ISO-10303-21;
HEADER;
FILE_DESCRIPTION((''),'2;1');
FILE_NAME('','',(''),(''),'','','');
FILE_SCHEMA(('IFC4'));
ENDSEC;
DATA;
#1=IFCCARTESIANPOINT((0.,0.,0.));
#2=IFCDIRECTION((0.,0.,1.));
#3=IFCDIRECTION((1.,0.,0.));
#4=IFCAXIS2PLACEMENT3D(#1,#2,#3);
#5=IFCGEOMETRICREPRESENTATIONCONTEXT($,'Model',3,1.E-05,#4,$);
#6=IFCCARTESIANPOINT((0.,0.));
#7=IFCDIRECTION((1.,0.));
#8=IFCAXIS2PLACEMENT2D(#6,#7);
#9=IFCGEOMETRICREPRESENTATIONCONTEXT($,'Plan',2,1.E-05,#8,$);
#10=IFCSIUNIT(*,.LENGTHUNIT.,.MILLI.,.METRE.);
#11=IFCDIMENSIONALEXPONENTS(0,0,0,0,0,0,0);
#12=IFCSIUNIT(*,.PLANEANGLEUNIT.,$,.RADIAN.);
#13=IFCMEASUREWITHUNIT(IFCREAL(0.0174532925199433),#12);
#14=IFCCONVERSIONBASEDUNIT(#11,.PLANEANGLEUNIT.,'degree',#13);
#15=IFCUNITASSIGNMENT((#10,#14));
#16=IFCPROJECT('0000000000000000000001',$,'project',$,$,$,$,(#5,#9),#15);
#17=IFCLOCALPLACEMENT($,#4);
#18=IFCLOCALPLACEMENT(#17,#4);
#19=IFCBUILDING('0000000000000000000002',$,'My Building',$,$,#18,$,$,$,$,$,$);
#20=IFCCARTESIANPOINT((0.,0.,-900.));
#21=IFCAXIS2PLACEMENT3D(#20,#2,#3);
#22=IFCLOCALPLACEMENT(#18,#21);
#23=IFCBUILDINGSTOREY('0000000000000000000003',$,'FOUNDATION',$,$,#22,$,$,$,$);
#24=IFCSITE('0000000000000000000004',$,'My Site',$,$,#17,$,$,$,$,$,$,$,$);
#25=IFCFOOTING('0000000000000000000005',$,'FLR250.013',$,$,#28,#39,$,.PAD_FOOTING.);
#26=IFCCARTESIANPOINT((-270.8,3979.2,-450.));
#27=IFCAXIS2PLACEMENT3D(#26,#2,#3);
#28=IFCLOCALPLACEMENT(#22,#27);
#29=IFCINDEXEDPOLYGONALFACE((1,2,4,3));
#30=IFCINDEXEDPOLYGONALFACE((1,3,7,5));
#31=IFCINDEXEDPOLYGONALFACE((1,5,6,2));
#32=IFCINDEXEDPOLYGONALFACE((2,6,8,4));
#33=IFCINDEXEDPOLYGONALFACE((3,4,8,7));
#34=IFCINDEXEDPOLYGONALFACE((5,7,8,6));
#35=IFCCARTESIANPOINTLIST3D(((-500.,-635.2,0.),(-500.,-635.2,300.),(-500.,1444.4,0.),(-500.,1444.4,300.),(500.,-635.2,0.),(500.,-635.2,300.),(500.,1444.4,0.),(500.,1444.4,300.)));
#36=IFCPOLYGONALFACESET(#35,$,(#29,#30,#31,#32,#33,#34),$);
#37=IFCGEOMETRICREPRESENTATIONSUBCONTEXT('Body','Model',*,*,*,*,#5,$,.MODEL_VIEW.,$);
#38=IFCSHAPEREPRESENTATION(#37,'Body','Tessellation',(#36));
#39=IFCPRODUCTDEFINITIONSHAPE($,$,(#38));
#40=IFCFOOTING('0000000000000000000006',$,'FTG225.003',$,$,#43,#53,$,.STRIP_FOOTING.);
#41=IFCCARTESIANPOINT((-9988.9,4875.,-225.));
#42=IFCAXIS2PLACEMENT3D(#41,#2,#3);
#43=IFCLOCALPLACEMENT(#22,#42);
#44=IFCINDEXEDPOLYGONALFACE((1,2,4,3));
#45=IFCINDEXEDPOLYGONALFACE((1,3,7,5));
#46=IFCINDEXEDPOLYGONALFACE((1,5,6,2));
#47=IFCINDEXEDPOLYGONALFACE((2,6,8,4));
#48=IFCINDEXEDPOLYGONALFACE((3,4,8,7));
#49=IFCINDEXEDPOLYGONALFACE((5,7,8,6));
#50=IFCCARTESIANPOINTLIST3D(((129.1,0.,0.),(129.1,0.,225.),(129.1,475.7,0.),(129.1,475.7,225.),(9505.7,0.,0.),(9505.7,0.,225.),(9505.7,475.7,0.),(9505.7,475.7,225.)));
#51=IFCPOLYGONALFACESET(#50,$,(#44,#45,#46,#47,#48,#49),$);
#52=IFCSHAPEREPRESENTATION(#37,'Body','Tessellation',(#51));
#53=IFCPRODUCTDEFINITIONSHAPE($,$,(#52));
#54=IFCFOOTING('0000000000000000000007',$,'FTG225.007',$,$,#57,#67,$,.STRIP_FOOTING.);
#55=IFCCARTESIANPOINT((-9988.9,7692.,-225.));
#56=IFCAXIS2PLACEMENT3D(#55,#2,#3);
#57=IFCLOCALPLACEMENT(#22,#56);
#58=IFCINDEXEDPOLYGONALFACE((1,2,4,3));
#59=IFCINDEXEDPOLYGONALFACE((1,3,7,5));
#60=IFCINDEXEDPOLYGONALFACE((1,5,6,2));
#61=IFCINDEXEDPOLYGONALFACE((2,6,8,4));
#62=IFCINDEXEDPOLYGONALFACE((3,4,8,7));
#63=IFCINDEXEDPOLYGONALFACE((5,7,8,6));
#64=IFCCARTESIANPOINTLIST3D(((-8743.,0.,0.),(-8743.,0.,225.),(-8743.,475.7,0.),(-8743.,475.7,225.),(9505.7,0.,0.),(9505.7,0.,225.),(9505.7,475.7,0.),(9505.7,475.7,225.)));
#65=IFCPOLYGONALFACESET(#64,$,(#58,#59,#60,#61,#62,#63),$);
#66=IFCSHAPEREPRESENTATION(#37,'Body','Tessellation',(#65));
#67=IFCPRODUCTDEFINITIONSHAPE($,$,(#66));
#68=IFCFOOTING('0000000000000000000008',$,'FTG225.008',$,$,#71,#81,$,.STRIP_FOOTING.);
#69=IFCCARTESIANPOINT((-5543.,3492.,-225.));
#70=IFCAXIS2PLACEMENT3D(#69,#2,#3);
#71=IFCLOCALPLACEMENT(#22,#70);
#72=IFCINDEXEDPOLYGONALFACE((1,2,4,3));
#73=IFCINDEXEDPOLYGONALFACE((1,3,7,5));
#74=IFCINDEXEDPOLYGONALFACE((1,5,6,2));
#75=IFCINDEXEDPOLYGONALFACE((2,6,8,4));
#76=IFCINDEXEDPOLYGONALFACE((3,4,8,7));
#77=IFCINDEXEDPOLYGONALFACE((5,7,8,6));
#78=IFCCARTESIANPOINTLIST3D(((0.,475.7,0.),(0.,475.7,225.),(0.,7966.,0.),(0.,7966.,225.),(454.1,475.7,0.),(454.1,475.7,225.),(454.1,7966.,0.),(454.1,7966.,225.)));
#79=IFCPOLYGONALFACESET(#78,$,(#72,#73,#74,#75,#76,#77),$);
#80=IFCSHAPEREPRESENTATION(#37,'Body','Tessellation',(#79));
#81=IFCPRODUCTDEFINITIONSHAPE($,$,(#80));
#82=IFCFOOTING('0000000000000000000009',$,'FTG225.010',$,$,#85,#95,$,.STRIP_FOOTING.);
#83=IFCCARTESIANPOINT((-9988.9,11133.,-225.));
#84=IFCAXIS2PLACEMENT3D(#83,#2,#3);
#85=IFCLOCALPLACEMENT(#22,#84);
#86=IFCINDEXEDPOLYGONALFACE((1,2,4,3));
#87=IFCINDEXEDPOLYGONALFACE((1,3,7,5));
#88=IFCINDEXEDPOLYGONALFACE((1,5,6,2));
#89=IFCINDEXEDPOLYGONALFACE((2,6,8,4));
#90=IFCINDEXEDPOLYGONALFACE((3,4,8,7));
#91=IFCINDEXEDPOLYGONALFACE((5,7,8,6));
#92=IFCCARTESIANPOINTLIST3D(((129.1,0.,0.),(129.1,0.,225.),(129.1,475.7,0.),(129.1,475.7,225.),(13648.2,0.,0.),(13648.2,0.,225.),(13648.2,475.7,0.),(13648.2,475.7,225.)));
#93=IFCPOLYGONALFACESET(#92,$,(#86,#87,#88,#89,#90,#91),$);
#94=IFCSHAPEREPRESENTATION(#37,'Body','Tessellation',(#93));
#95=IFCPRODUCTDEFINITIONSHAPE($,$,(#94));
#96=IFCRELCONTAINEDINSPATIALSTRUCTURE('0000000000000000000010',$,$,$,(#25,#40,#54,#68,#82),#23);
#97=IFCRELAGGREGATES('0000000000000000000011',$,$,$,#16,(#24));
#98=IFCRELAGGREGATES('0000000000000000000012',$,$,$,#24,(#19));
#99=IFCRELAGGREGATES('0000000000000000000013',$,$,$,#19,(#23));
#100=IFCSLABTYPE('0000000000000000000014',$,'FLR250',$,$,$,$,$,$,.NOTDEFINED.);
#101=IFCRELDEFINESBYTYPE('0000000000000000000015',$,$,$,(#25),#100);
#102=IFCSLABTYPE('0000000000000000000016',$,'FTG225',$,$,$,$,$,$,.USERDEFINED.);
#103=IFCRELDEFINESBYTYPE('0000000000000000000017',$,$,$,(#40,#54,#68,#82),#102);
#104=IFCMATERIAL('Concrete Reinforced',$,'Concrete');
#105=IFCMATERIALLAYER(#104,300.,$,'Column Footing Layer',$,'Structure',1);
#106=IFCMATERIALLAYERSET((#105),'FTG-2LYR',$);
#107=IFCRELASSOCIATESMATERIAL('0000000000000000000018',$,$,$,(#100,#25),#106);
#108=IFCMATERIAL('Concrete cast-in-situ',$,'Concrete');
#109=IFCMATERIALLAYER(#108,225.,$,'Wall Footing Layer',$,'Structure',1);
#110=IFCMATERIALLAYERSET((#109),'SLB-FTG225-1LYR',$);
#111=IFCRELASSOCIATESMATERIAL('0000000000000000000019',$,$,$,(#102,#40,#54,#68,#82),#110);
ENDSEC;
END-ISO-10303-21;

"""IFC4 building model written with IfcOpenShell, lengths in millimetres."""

from ifc_helpers import new_model, entity, si_unit, converted_unit, frame, origin_with_axes, origin_2d_with_axis, place, context, subcontext, project, spatial, line, indexed_curve, outline, extrude, material, layer, layer_set, layer_usage, type_object, element, save


model = new_model("IFC4")

# Units and contexts
model_context = context("Model", 3, precision=1e-05, world=origin_with_axes())
plan_context = context("Plan", 2, precision=1e-05, world=origin_2d_with_axis())
body_context = subcontext(model_context, "Body", "Model", "MODEL_VIEW")
ifc_project = project(units=[si_unit("LENGTHUNIT", "METRE", prefix="MILLI"), converted_unit("PLANEANGLEUNIT", "degree", entity("IfcReal", 0.0174532925199433), si_unit("PLANEANGLEUNIT", "RADIAN"), dimensions=[0, 0, 0, 0, 0, 0, 0])], contexts=[model_context, plan_context])

# Site, building, storey
site_placement = place(None, origin_with_axes())
site = spatial("IfcSite", under=ifc_project, at=site_placement, Name="My Site")
building_placement = place(site_placement, origin_with_axes())
building = spatial("IfcBuilding", under=site, at=building_placement, Name="My Building")
storey_placement = place(building_placement, frame((0.0, 0.0, -900.0), z_axis=(0.0, 0.0, 1.0), x_axis=(1.0, 0.0, 0.0)))
storey = spatial("IfcBuildingStorey", under=building, at=storey_placement, Name="FOUNDATION")

# Footings
ifc_material_1 = material(Name="Concrete Reinforced", Category="Concrete")
ifc_layer_1 = layer(ifc_material_1, 300.0, Name="Column Footing Layer", Category="Structure", Priority=1)
ifc_layer_set_1 = layer_set([ifc_layer_1], Name="FTG-2LYR")
slab_type_1 = type_object("IfcSlabType", Name="FLR250", PredefinedType="NOTDEFINED", material=ifc_layer_set_1)
ifc_layer_usage_1 = layer_usage(ifc_layer_set_1, "AXIS3", "POSITIVE", 0.0)
footing_1_placement = place(storey_placement, frame((-270.8, 3979.2, -450.0), z_axis=(0.0, 0.0, 1.0), x_axis=(1.0, 0.0, 0.0)))
element("IfcFooting", 1, at=footing_1_placement, inside=storey, type_object=slab_type_1, material=ifc_layer_usage_1, Name="FLR250.013", PredefinedType="PAD_FOOTING", context=body_context, shape_type="SweptSolid", body=[
    extrude(outline(indexed_curve([(-500.0, -635.2), (500.0, -635.2), (500.0, 1444.4), (-500.0, 1444.4)], segments=[line(3, 2), line(2, 1), line(1, 4), line(4, 3)], self_intersect=False)), None, (0.0, 0.0, 1.0), 300.0),
])
ifc_material_2 = material(Name="Concrete cast-in-situ", Category="Concrete")
ifc_layer_2 = layer(ifc_material_2, 225.0, Name="Wall Footing Layer", Category="Structure", Priority=1)
ifc_layer_set_2 = layer_set([ifc_layer_2], Name="SLB-FTG225-1LYR")
ifc_layer_usage_2 = layer_usage(ifc_layer_set_2, "AXIS3", "POSITIVE", 0.0)
slab_type_2 = type_object("IfcSlabType", Name="FTG225", PredefinedType="USERDEFINED", material=ifc_layer_set_2)
footing_2_placement = place(storey_placement, frame((-9988.9, 4875.0, -225.0), z_axis=(0.0, 0.0, 1.0), x_axis=(1.0, 0.0, 0.0)))
element("IfcFooting", 2, at=footing_2_placement, inside=storey, type_object=slab_type_2, material=ifc_layer_usage_2, Name="FTG225.003", PredefinedType="STRIP_FOOTING", context=body_context, shape_type="SweptSolid", body=[
    extrude(outline(indexed_curve([(129.1, 0.0), (9505.7, 0.0), (9505.7, 475.7), (129.1, 475.7)], segments=[line(3, 2), line(2, 1), line(1, 4), line(4, 3)], self_intersect=False)), None, (0.0, 0.0, 1.0), 225.0),
])
ifc_layer_usage_3 = layer_usage(ifc_layer_set_2, "AXIS3", "POSITIVE", 0.0)
footing_3_placement = place(storey_placement, frame((-9988.9, 7692.0, -225.0), z_axis=(0.0, 0.0, 1.0), x_axis=(1.0, 0.0, 0.0)))
element("IfcFooting", 3, at=footing_3_placement, inside=storey, type_object=slab_type_2, material=ifc_layer_usage_3, Name="FTG225.007", PredefinedType="STRIP_FOOTING", context=body_context, shape_type="SweptSolid", body=[
    extrude(outline(indexed_curve([(-8743.0, 0.0), (9505.7, 0.0), (9505.7, 475.7), (-8743.0, 475.7)], segments=[line(3, 2), line(2, 1), line(1, 4), line(4, 3)], self_intersect=False)), None, (0.0, 0.0, 1.0), 225.0),
])
ifc_layer_usage_4 = layer_usage(ifc_layer_set_2, "AXIS3", "POSITIVE", 0.0)
footing_4_placement = place(storey_placement, frame((-5543.0, 3492.0, -225.0), z_axis=(0.0, 0.0, 1.0), x_axis=(1.0, 0.0, 0.0)))
element("IfcFooting", 4, at=footing_4_placement, inside=storey, type_object=slab_type_2, material=ifc_layer_usage_4, Name="FTG225.008", PredefinedType="STRIP_FOOTING", context=body_context, shape_type="SweptSolid", body=[
    extrude(outline(indexed_curve([(454.1, 7966.0), (454.1, 475.7), (0.0, 475.7), (0.0, 7966.0)], segments=[line(3, 2), line(2, 1), line(1, 4), line(4, 3)], self_intersect=False)), None, (0.0, 0.0, 1.0), 225.0),
])
ifc_layer_usage_5 = layer_usage(ifc_layer_set_2, "AXIS3", "POSITIVE", 0.0)
footing_5_placement = place(storey_placement, frame((-9988.9, 11133.0, -225.0), z_axis=(0.0, 0.0, 1.0), x_axis=(1.0, 0.0, 0.0)))
element("IfcFooting", 5, at=footing_5_placement, inside=storey, type_object=slab_type_2, material=ifc_layer_usage_5, Name="FTG225.010", PredefinedType="STRIP_FOOTING", context=body_context, shape_type="SweptSolid", body=[
    extrude(outline(indexed_curve([(13648.2, 475.7), (13648.2, 0.0), (129.1, 0.0), (129.1, 475.7)], segments=[line(3, 2), line(2, 1), line(1, 4), line(4, 3)], self_intersect=False)), None, (0.0, 0.0, 1.0), 225.0),
])

save(model, "model.ifc")
